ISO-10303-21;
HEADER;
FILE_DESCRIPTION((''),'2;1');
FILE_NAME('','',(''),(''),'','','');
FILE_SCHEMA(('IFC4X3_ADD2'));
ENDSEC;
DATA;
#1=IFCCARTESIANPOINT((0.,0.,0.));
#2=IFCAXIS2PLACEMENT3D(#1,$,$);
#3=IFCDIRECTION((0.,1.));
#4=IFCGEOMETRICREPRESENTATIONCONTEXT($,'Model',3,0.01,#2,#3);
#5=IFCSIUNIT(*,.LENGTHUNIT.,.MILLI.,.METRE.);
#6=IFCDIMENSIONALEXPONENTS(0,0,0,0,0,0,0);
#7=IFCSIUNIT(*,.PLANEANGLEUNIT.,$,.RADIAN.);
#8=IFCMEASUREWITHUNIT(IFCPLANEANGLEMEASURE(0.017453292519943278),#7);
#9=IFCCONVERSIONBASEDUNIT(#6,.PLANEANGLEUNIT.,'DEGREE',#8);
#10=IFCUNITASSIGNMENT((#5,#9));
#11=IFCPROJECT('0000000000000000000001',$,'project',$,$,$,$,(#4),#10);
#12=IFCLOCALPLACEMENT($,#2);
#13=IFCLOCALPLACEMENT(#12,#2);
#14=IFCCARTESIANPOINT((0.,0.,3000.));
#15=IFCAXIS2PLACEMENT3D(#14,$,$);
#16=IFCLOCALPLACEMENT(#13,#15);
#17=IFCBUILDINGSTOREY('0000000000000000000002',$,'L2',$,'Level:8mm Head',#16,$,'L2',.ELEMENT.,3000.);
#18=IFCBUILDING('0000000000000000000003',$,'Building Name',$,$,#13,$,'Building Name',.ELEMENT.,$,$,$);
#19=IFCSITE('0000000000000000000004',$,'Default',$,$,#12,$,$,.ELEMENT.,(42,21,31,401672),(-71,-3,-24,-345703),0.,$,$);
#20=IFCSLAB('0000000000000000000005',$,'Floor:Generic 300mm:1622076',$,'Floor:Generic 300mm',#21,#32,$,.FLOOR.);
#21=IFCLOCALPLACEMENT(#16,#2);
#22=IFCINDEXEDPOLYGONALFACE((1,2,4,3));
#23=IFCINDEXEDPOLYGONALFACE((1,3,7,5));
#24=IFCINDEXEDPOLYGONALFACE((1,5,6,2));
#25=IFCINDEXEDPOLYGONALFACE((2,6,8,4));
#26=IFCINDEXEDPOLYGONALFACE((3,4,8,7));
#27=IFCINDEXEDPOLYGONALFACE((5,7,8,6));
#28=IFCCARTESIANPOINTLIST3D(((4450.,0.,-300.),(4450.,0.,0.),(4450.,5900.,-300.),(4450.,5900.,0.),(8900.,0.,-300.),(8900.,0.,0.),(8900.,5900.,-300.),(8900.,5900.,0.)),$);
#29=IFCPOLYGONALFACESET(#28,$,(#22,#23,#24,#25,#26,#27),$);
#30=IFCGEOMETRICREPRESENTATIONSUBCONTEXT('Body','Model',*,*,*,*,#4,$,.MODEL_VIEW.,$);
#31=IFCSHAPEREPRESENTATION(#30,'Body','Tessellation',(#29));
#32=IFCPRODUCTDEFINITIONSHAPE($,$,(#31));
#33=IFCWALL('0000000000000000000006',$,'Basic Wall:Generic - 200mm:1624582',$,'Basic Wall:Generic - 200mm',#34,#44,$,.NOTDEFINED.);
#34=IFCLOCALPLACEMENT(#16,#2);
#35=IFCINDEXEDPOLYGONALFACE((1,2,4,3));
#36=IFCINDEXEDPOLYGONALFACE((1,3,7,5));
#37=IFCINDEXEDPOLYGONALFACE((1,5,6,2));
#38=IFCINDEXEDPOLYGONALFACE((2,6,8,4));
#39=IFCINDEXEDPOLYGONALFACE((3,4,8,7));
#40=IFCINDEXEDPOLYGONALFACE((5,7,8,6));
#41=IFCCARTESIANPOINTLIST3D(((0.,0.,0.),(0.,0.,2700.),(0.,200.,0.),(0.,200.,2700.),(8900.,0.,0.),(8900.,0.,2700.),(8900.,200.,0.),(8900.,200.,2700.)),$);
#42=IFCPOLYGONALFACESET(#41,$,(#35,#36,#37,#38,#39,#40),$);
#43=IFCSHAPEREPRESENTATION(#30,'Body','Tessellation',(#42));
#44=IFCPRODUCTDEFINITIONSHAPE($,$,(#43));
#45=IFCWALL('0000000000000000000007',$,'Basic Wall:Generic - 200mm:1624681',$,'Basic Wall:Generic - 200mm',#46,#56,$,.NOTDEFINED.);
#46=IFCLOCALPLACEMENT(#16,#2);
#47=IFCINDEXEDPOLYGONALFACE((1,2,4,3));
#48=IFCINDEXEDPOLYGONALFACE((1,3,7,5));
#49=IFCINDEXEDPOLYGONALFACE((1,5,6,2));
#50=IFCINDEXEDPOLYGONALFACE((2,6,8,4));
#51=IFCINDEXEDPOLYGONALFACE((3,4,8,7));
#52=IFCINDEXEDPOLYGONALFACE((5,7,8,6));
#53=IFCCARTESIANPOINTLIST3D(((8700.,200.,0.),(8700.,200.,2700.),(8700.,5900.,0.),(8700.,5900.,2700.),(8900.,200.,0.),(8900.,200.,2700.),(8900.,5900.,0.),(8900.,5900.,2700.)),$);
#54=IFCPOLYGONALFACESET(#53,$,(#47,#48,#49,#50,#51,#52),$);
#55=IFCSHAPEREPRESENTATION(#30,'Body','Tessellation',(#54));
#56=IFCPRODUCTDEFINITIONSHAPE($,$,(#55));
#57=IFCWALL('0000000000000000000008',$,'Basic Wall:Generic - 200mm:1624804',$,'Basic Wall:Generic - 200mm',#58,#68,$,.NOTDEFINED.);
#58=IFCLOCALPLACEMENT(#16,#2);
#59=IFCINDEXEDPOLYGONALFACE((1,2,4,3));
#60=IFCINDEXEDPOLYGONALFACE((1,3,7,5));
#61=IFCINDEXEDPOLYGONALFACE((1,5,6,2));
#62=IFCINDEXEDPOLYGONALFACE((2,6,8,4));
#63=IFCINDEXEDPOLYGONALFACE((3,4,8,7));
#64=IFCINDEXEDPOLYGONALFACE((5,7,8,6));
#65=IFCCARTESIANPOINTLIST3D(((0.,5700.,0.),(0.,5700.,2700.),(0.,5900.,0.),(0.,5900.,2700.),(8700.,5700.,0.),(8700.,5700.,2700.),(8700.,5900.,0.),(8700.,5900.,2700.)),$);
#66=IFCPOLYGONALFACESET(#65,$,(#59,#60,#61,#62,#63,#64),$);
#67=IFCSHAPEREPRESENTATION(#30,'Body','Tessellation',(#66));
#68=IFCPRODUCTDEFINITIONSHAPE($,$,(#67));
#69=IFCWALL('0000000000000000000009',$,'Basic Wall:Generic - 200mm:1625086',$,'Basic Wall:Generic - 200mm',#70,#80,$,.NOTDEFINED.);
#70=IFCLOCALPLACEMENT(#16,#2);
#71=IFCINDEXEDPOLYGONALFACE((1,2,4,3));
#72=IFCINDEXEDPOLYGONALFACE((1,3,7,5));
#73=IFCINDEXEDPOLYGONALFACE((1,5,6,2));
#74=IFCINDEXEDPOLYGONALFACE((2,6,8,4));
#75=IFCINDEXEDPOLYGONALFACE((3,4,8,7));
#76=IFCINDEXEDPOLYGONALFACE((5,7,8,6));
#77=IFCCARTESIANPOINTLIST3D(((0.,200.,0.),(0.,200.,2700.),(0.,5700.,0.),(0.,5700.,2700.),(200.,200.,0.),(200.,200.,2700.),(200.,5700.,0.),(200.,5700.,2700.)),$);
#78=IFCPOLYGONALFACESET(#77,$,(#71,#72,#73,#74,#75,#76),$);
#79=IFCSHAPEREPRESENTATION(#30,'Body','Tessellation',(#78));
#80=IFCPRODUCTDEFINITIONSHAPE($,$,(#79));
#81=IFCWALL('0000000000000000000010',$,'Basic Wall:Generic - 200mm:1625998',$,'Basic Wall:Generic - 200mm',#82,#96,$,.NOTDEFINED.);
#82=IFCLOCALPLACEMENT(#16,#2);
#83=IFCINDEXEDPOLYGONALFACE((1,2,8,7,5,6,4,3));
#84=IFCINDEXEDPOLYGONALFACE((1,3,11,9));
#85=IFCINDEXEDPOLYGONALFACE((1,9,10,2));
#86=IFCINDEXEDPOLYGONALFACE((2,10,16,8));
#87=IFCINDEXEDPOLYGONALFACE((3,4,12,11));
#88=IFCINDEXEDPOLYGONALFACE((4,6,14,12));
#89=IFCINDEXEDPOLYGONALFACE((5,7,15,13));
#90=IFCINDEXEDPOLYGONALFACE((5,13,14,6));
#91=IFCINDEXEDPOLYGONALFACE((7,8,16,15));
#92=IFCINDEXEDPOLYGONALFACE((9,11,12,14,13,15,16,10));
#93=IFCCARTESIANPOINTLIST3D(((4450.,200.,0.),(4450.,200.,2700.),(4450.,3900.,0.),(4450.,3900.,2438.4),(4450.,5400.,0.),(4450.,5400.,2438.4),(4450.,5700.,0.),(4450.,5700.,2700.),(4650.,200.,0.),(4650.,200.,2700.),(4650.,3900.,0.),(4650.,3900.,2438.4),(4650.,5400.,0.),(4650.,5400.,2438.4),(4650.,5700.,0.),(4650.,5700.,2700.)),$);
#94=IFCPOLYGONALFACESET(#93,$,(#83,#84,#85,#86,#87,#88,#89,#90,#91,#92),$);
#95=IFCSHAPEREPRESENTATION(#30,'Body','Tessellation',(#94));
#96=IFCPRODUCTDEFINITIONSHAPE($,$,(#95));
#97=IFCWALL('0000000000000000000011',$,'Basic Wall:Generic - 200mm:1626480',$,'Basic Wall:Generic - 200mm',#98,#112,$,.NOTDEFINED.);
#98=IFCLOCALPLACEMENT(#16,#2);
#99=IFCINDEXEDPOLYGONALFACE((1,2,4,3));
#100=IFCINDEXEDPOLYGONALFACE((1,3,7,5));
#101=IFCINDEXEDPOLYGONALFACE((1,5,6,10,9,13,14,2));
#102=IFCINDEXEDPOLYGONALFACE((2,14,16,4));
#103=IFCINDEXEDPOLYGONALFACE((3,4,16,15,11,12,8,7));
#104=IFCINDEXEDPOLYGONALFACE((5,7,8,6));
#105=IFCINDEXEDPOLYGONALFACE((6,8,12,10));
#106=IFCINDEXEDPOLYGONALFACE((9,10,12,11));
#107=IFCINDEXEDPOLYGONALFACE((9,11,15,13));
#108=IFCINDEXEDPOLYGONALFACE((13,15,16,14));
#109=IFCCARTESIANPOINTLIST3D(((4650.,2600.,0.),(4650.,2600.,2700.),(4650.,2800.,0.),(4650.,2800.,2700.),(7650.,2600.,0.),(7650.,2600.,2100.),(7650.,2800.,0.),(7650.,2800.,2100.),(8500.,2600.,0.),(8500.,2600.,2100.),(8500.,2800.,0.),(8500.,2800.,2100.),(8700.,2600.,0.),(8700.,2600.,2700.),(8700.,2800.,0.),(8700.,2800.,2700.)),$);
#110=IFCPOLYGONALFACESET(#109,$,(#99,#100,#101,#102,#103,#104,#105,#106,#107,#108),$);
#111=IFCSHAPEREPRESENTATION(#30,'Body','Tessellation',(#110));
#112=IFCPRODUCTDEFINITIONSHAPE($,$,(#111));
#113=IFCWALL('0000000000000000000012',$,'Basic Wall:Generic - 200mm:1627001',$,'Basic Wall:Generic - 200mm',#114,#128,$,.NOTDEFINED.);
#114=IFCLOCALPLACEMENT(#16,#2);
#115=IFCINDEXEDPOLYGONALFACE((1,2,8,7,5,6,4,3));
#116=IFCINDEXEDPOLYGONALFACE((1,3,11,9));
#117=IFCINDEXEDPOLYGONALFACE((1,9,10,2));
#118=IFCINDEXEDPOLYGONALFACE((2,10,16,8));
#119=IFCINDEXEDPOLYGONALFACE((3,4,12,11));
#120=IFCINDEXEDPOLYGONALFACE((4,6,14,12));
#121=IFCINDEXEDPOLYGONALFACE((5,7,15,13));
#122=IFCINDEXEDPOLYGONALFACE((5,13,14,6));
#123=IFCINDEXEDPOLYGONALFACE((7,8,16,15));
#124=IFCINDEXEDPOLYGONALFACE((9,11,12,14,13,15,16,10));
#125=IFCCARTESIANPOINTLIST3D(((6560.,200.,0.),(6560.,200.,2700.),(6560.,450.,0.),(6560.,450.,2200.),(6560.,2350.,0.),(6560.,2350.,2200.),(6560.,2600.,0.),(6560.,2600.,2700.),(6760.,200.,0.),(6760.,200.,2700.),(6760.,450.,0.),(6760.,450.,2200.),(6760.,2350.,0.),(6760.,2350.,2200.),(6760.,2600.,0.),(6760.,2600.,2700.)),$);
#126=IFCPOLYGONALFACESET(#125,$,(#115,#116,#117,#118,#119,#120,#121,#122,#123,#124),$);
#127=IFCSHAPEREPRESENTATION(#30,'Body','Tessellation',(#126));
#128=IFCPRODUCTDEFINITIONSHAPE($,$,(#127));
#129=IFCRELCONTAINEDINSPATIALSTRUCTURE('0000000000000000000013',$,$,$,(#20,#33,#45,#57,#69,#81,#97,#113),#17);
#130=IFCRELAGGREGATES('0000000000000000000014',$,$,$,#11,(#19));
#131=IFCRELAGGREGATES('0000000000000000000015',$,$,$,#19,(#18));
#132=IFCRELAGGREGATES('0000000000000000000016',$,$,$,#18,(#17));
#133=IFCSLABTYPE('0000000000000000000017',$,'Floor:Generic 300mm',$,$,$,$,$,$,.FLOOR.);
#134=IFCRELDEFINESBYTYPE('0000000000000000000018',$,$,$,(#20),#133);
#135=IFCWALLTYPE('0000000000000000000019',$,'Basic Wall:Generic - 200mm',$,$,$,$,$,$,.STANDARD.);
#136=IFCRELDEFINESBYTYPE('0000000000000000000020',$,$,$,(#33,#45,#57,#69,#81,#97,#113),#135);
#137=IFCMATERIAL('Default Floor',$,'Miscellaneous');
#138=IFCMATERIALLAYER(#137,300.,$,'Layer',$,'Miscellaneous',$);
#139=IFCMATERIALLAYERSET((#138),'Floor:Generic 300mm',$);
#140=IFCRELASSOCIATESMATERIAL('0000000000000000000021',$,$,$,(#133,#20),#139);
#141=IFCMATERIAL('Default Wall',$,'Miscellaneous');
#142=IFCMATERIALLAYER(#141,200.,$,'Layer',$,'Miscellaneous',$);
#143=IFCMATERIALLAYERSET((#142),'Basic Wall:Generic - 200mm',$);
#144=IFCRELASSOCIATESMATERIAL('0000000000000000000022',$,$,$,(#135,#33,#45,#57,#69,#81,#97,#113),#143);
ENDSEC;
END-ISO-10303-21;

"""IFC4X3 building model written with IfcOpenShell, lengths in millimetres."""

from ifc_helpers import new_model, entity, si_unit, converted_unit, direction, frame, frame_2d, origin, origin_2d_with_axis, place, context, subcontext, project, spatial, rectangle, extrude, material, layer, layer_set, layer_usage, type_object, element, save


model = new_model("IFC4X3")

# Units and contexts
model_context = context("Model", 3, precision=0.01, world=origin(), true_north=direction((0.0, 1.0)))
body_context = subcontext(model_context, "Body", "Model", "MODEL_VIEW")
ifc_project = project(units=[si_unit("LENGTHUNIT", "METRE", prefix="MILLI"), converted_unit("PLANEANGLEUNIT", "DEGREE", entity("IfcPlaneAngleMeasure", 0.017453292519943278), si_unit("PLANEANGLEUNIT", "RADIAN"), dimensions=[0, 0, 0, 0, 0, 0, 0])], contexts=[model_context])

# Site, building, storey
site_placement = place(None, origin())
site = spatial("IfcSite", under=ifc_project, at=site_placement, Name="Default", CompositionType="ELEMENT", RefLatitude=(42, 21, 31, 401672), RefLongitude=(-71, -3, -24, -345703), RefElevation=0.0)
building_placement = place(site_placement, origin())
building = spatial("IfcBuilding", under=site, at=building_placement, Name="Building Name", LongName="Building Name", CompositionType="ELEMENT")
storey_placement = place(building_placement, frame((0.0, 0.0, 3000.0)))
storey = spatial("IfcBuildingStorey", under=building, at=storey_placement, Name="L2", ObjectType="Level:8mm Head", LongName="L2", CompositionType="ELEMENT", Elevation=3000.0)

# Slab
ifc_material_1 = material(Name="Default Floor", Category="Miscellaneous")
ifc_layer_1 = layer(ifc_material_1, 300.0, Name="Layer", Category="Miscellaneous")
ifc_layer_set_1 = layer_set([ifc_layer_1], Name="Floor:Generic 300mm")
ifc_layer_usage = layer_usage(ifc_layer_set_1, "AXIS3", "POSITIVE", 0.0)
slab_type = type_object("IfcSlabType", Name="Floor:Generic 300mm", PredefinedType="FLOOR", material=ifc_layer_set_1)
slab_placement = place(storey_placement, origin())
element("IfcSlab", 1, at=slab_placement, inside=storey, type_object=slab_type, material=ifc_layer_usage, Name="Floor:Generic 300mm:1622076", ObjectType="Floor:Generic 300mm", PredefinedType="FLOOR", context=body_context, shape_type="SweptSolid", body=[
    extrude(rectangle(XDim=5900.0, YDim=4450.0, at=origin_2d_with_axis()), frame((6675.0, 2950.0, 0.0), z_axis=(0.0, 0.0, -1.0), x_axis=(0.0, 1.0, 0.0)), (0.0, 0.0, 1.0), 300.0),
])

# Walls
ifc_material_2 = material(Name="Default Wall", Category="Miscellaneous")
ifc_layer_2 = layer(ifc_material_2, 200.0, Name="Layer", Category="Miscellaneous")
ifc_layer_set_2 = layer_set([ifc_layer_2], Name="Basic Wall:Generic - 200mm")
wall_type = type_object("IfcWallType", Name="Basic Wall:Generic - 200mm", PredefinedType="STANDARD", material=ifc_layer_set_2)
wall_1_placement = place(storey_placement, frame((0.0, 100.0, 0.0)))
element("IfcWall", 2, at=wall_1_placement, inside=storey, type_object=wall_type, material=ifc_layer_set_2, Name="Basic Wall:Generic - 200mm:1624582", ObjectType="Basic Wall:Generic - 200mm", PredefinedType="NOTDEFINED", context=body_context, shape_type="SweptSolid", body=[
    extrude(rectangle(XDim=8900.0, YDim=200.0, at=frame_2d((4450.0, 0.0), x_axis=(-1.0, 0.0))), origin(), (0.0, 0.0, 1.0), 2700.0),
])
wall_2_placement = place(storey_placement, frame((8800.0, 200.0, 0.0), z_axis=(0.0, 0.0, 1.0), x_axis=(0.0, 1.0, 0.0)))
element("IfcWall", 3, at=wall_2_placement, inside=storey, type_object=wall_type, material=ifc_layer_set_2, Name="Basic Wall:Generic - 200mm:1624681", ObjectType="Basic Wall:Generic - 200mm", PredefinedType="NOTDEFINED", context=body_context, shape_type="SweptSolid", body=[
    extrude(rectangle(XDim=5700.0, YDim=200.0, at=frame_2d((2850.0, 0.0), x_axis=(-1.0, 0.0))), origin(), (0.0, 0.0, 1.0), 2700.0),
])
wall_3_placement = place(storey_placement, frame((8700.0, 5800.0, 0.0), z_axis=(0.0, 0.0, 1.0), x_axis=(-1.0, 0.0, 0.0)))
element("IfcWall", 4, at=wall_3_placement, inside=storey, type_object=wall_type, material=ifc_layer_set_2, Name="Basic Wall:Generic - 200mm:1624804", ObjectType="Basic Wall:Generic - 200mm", PredefinedType="NOTDEFINED", context=body_context, shape_type="SweptSolid", body=[
    extrude(rectangle(XDim=8700.0, YDim=200.0, at=frame_2d((4350.0, 0.0), x_axis=(-1.0, 0.0))), origin(), (0.0, 0.0, 1.0), 2700.0),
])
wall_4_placement = place(storey_placement, frame((100.0, 5700.0, 0.0), z_axis=(0.0, 0.0, 1.0), x_axis=(0.0, -1.0, 0.0)))
element("IfcWall", 5, at=wall_4_placement, inside=storey, type_object=wall_type, material=ifc_layer_set_2, Name="Basic Wall:Generic - 200mm:1625086", ObjectType="Basic Wall:Generic - 200mm", PredefinedType="NOTDEFINED", context=body_context, shape_type="SweptSolid", body=[
    extrude(rectangle(XDim=5500.0, YDim=200.0, at=frame_2d((2750.0, 0.0), x_axis=(-1.0, 0.0))), origin(), (0.0, 0.0, 1.0), 2700.0),
])

# Walls, openings
wall_5_placement = place(storey_placement, frame((4550.0, 200.0, 0.0), z_axis=(0.0, 0.0, 1.0), x_axis=(0.0, 1.0, 0.0)))
wall_5 = element("IfcWall", 6, at=wall_5_placement, inside=storey, type_object=wall_type, material=ifc_layer_set_2, Name="Basic Wall:Generic - 200mm:1625998", ObjectType="Basic Wall:Generic - 200mm", PredefinedType="NOTDEFINED", context=body_context, shape_type="SweptSolid", body=[
    extrude(rectangle(XDim=5500.0, YDim=200.0, at=frame_2d((2750.0, 0.0), x_axis=(1.0, 0.0))), origin(), (0.0, 0.0, 1.0), 2700.0),
])
opening_1_placement = place(wall_5_placement, frame((3700.0, 100.0, 0.0)))
element("IfcOpeningElement", 7, at=opening_1_placement, cuts=wall_5, PredefinedType="OPENING", context=body_context, shape_type="SweptSolid", body=[
    extrude(rectangle(XDim=2438.4, YDim=1500.0, at=frame_2d((0.0, 0.0), x_axis=(1.0, 0.0))), frame((750.0, -200.0, 1219.2), z_axis=(0.0, 1.0, 0.0), x_axis=(0.0, 0.0, -1.0)), (0.0, 0.0, 1.0), 200.0),
])
wall_6_placement = place(storey_placement, frame((8700.0, 2700.0, 0.0), z_axis=(0.0, 0.0, 1.0), x_axis=(-1.0, 0.0, 0.0)))
wall_6 = element("IfcWall", 8, at=wall_6_placement, inside=storey, type_object=wall_type, material=ifc_layer_set_2, Name="Basic Wall:Generic - 200mm:1626480", ObjectType="Basic Wall:Generic - 200mm", PredefinedType="NOTDEFINED", context=body_context, shape_type="SweptSolid", body=[
    extrude(rectangle(XDim=4050.0, YDim=200.0, at=frame_2d((2025.0, 0.0), x_axis=(1.0, 0.0))), origin(), (0.0, 0.0, 1.0), 2700.0),
])
opening_2_placement = place(wall_6_placement, frame((200.0, -100.0, 0.0)))
element("IfcOpeningElement", 9, at=opening_2_placement, cuts=wall_6, PredefinedType="OPENING", context=body_context, shape_type="SweptSolid", body=[
    extrude(rectangle(XDim=2100.0, YDim=850.0, at=frame_2d((1050.0, 425.0), x_axis=(1.0, 0.0))), frame((0.0, 0.0, 0.0), z_axis=(0.0, 1.0, 0.0), x_axis=(0.0, 0.0, 1.0)), (0.0, 0.0, 1.0), 200.0),
])
wall_7_placement = place(storey_placement, frame((6660.0, 2600.0, 0.0), z_axis=(0.0, 0.0, 1.0), x_axis=(0.0, -1.0, 0.0)))
wall_7 = element("IfcWall", 10, at=wall_7_placement, inside=storey, type_object=wall_type, material=ifc_layer_set_2, Name="Basic Wall:Generic - 200mm:1627001", ObjectType="Basic Wall:Generic - 200mm", PredefinedType="NOTDEFINED", context=body_context, shape_type="SweptSolid", body=[
    extrude(rectangle(XDim=2400.0, YDim=200.0, at=frame_2d((1200.0, 0.0), x_axis=(-1.0, 0.0))), origin(), (0.0, 0.0, 1.0), 2700.0),
])
opening_3_placement = place(wall_7_placement, frame((2150.0, -100.0, 0.0)))
element("IfcOpeningElement", 11, at=opening_3_placement, cuts=wall_7, PredefinedType="OPENING", context=body_context, shape_type="SweptSolid", body=[
    extrude(rectangle(XDim=2200.0, YDim=1900.0, at=frame_2d((0.0, 0.0), x_axis=(1.0, 0.0))), frame((-950.0, 0.0, 1100.0), z_axis=(0.0, 1.0, 0.0), x_axis=(0.0, 0.0, -1.0)), (0.0, 0.0, 1.0), 200.0),
])

save(model, "model.ifc")
